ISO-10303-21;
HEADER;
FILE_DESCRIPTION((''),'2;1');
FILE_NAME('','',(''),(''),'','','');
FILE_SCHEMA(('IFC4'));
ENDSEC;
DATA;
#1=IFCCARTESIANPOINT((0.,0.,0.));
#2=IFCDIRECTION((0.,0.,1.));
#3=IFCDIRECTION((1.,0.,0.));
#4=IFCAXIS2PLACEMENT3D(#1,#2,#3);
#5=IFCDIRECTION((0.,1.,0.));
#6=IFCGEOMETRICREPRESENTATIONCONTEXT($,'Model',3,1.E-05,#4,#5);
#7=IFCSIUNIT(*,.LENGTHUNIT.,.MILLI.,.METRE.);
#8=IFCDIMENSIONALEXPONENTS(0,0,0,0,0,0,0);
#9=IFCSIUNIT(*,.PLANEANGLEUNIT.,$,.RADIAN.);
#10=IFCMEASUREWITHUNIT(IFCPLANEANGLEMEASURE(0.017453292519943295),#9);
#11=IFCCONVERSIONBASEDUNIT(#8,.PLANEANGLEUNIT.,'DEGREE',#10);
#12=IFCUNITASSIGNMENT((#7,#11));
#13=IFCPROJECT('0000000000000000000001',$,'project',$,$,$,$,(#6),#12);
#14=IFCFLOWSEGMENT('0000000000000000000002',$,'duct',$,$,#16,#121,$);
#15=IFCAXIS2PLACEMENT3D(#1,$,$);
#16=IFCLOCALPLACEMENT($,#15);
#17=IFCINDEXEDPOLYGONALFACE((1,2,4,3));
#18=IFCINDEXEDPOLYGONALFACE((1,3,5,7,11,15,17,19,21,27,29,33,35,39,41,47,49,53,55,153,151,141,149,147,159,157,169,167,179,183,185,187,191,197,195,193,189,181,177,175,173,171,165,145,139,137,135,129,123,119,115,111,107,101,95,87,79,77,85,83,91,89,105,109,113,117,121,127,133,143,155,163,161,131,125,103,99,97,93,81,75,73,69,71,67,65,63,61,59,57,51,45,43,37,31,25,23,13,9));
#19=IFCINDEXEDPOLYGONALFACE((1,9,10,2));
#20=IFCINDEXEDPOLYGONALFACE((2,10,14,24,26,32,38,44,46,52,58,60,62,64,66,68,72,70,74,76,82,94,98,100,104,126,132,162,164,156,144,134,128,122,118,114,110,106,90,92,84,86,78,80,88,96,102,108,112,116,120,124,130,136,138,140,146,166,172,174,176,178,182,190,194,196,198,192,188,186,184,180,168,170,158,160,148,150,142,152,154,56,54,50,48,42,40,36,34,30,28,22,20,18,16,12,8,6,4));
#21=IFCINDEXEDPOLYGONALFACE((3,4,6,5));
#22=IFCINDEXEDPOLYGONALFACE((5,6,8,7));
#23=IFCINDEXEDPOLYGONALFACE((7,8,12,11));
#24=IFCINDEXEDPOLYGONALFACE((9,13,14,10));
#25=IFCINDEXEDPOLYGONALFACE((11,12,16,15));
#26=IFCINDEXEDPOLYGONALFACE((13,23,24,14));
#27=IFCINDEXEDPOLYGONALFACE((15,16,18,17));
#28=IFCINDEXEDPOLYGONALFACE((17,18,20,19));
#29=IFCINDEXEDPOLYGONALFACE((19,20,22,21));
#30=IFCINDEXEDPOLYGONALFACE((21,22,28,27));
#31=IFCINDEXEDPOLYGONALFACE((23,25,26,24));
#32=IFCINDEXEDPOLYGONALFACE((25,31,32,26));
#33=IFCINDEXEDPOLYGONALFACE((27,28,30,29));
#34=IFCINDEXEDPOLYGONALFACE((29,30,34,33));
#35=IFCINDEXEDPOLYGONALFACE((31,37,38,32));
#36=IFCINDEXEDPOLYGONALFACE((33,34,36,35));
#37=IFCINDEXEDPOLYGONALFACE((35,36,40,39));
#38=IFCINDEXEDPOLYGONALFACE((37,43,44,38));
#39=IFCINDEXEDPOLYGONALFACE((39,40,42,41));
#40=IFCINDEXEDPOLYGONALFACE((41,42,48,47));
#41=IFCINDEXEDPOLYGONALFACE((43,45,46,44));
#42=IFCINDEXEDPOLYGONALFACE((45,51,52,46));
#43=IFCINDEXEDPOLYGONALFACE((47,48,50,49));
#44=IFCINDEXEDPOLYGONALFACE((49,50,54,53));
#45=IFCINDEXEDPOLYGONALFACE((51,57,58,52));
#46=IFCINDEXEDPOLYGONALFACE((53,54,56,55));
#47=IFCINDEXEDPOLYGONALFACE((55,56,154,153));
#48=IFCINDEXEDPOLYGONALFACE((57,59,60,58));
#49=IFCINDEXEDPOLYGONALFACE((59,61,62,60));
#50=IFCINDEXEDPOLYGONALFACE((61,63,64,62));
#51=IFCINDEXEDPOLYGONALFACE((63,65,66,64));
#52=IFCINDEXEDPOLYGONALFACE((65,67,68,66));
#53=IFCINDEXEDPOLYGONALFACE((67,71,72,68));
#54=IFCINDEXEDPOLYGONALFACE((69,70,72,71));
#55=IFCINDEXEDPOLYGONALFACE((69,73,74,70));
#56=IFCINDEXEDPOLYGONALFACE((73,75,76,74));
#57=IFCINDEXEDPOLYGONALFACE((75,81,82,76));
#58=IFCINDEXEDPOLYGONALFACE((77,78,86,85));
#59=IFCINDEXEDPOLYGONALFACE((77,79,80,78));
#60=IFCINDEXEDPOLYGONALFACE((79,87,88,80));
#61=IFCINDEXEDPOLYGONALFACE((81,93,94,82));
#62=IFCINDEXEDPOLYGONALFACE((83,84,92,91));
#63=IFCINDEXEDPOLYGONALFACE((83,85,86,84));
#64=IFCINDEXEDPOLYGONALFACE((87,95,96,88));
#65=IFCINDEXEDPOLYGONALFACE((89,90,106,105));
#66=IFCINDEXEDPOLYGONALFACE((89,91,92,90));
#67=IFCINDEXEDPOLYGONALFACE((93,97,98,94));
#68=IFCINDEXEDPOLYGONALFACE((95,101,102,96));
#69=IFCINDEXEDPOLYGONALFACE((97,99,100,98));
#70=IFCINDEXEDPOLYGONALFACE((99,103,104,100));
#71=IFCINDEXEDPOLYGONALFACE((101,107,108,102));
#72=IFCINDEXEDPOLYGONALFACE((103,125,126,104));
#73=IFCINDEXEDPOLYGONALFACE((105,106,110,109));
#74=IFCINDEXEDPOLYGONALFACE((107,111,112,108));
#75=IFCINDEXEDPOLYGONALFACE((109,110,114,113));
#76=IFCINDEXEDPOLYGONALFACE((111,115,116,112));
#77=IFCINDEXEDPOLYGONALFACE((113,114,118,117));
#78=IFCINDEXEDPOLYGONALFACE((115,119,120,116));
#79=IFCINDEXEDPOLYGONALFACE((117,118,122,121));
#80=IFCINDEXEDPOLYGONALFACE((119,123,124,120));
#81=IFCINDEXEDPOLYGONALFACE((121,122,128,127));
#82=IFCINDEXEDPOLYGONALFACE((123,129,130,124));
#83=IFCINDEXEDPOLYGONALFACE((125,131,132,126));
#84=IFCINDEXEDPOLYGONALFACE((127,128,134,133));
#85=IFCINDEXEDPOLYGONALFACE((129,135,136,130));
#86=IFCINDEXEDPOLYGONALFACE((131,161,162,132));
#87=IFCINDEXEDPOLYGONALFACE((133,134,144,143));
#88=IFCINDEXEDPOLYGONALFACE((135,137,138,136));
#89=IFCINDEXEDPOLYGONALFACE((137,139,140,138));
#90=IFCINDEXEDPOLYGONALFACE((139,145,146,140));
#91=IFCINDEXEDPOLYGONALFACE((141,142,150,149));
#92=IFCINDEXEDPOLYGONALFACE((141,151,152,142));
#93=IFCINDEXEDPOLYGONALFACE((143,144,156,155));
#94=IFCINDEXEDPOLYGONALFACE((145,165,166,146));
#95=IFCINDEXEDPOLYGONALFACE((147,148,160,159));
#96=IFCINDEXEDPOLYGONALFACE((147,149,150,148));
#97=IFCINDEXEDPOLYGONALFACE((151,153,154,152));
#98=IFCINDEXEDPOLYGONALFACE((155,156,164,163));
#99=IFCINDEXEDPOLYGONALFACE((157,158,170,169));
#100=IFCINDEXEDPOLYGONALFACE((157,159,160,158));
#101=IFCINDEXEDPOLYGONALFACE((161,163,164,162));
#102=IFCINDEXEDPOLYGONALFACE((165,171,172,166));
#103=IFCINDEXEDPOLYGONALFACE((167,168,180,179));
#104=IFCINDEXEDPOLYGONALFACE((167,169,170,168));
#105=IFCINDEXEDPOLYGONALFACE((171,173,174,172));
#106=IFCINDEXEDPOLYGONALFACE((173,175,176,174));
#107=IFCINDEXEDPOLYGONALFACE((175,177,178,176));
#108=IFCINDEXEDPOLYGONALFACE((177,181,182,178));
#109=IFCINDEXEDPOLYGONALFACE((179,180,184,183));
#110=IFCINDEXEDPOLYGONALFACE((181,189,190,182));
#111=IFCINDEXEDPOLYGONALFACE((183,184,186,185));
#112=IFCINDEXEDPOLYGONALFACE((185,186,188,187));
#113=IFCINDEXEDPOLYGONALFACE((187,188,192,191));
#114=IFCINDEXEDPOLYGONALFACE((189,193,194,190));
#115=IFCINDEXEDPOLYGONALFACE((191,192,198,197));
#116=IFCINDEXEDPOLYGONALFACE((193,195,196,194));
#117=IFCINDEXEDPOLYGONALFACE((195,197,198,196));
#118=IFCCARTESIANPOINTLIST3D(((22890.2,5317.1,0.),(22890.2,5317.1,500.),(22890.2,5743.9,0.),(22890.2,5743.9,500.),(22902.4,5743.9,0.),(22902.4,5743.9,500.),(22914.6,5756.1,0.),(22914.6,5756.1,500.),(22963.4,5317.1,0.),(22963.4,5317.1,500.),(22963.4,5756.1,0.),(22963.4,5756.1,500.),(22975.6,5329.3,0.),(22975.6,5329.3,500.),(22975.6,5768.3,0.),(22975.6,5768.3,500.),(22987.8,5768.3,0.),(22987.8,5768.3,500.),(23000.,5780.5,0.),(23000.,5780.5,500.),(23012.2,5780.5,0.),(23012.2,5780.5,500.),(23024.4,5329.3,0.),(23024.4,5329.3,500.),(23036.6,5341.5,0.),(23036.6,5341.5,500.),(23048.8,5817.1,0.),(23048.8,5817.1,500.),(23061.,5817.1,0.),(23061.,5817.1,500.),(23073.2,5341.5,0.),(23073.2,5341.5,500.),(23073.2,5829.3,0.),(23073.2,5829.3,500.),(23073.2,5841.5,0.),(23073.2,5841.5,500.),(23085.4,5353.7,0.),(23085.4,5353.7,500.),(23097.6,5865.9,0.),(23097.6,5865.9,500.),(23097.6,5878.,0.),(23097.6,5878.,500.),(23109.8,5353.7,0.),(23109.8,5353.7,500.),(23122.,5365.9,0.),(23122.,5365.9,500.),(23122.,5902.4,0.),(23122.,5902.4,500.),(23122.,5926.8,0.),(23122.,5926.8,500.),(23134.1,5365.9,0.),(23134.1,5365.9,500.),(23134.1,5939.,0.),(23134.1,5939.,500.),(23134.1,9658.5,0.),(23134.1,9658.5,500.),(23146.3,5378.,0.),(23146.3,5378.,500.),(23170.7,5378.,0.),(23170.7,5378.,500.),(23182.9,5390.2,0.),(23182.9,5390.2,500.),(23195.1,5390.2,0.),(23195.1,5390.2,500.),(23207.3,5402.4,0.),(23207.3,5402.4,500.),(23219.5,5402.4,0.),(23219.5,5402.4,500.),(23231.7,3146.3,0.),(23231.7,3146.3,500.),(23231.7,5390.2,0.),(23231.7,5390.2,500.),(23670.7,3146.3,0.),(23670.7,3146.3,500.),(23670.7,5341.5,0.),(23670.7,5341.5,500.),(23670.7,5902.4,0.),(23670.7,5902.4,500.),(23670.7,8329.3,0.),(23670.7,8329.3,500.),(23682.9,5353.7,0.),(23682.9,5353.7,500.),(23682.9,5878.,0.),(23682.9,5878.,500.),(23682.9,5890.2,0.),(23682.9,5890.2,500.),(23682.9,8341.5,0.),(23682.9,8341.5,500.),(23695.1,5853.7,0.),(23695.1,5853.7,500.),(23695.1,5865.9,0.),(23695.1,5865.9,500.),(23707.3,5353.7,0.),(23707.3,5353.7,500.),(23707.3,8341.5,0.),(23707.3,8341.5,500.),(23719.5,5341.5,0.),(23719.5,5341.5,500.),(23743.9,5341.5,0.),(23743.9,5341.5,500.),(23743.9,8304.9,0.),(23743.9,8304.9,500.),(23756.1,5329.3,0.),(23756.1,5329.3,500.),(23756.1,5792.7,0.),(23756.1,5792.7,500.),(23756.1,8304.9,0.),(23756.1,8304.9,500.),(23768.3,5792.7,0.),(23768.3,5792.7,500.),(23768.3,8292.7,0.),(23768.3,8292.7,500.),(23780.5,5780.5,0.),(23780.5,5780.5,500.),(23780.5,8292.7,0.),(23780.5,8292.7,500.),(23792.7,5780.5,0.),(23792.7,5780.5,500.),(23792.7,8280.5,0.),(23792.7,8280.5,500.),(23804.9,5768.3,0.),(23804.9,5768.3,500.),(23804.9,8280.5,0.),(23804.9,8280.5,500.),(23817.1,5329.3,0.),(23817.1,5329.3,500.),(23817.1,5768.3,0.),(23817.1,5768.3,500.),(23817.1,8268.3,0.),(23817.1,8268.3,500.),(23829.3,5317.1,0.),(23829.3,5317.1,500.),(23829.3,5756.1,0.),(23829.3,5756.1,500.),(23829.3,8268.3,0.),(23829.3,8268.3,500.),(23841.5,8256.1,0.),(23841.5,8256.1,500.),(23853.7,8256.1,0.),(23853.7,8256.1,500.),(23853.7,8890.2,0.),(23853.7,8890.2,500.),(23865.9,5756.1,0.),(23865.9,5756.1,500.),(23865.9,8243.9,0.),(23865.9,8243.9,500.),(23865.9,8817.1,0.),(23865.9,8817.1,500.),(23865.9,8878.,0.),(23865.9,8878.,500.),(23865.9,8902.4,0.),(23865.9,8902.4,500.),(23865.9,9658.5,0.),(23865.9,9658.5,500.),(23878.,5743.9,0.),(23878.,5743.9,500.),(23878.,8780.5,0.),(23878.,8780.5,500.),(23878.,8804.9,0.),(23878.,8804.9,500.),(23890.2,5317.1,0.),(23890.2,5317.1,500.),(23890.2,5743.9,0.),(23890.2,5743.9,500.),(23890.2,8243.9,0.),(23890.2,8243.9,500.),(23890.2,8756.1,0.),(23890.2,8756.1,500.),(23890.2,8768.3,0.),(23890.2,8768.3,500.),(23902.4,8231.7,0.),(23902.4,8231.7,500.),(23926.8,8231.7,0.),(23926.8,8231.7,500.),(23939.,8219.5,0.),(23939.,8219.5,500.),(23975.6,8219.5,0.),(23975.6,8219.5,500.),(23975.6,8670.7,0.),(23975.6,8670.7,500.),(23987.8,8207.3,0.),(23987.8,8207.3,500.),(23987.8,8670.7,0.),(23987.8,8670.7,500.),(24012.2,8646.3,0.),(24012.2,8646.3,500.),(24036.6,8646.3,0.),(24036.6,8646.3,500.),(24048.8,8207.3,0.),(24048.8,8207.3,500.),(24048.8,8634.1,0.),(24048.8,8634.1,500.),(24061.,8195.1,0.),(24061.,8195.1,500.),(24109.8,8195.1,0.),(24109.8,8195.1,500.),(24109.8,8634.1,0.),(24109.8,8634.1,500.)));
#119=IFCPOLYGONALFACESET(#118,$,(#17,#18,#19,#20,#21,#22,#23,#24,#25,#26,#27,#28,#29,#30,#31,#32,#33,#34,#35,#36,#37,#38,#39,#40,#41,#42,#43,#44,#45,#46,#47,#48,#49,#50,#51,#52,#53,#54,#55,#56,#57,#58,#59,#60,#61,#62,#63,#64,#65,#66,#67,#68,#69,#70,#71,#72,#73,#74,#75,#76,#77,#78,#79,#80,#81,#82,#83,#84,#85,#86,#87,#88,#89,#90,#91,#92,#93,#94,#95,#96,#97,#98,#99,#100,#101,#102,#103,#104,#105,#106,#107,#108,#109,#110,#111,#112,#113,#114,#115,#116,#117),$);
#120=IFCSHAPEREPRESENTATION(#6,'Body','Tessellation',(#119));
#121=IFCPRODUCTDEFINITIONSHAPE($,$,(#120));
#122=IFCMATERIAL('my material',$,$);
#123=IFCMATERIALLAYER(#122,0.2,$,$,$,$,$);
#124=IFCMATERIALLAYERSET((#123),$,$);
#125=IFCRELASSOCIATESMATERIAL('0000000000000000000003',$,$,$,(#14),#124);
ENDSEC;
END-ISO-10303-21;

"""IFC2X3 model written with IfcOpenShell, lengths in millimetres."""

from ifc_helpers import new_model, entity, si_unit, converted_unit, direction, origin_with_axes, place, context, project, polyline, outline, extrude, material, layer, layer_set, layer_usage, element, save


model = new_model("IFC2X3")

# Units and contexts
model_context = context("Model", 3, precision=1e-05, world=origin_with_axes(), true_north=direction((0.0, 1.0, 0.0)))
ifc_project = project(units=[si_unit("LENGTHUNIT", "METRE", prefix="MILLI"), converted_unit("PLANEANGLEUNIT", "DEGREE", entity("IfcPlaneAngleMeasure", 0.017453292519943295), si_unit("PLANEANGLEUNIT", "RADIAN"), dimensions=[0, 0, 0, 0, 0, 0, 0])], contexts=[model_context])

# Flow segment
ifc_material_1 = material(Name="my material")
ifc_layer_1 = layer(ifc_material_1, 0.2)
ifc_layer_set_1 = layer_set([ifc_layer_1])
ifc_layer_usage_1 = layer_usage(ifc_layer_set_1, "AXIS2", "POSITIVE", -0.1)
flow_segment_1_placement = place(None, origin_with_axes())
element("IfcFlowSegment", 1, at=flow_segment_1_placement, material=ifc_layer_usage_1, Name="duct", context=model_context, shape_type="SweptSolid", body=[
    extrude(outline(polyline([(22890.2, 5317.1), (22963.4, 5317.1), (22975.6, 5329.3), (23024.4, 5329.3), (23036.6, 5341.5), (23073.2, 5341.5), (23085.4, 5353.7), (23109.8, 5353.7), (23122.0, 5365.9), (23134.1, 5365.9), (23146.3, 5378.0), (23170.7, 5378.0), (23182.9, 5390.2), (23195.1, 5390.2), (23207.3, 5402.4), (23219.5, 5402.4), (23231.7, 5390.2), (23231.7, 3146.3), (23670.7, 3146.3), (23670.7, 5341.5), (23682.9, 5353.7), (23707.3, 5353.7), (23719.5, 5341.5), (23743.9, 5341.5), (23756.1, 5329.3), (23817.1, 5329.3), (23829.3, 5317.1), (23890.2, 5317.1), (23890.2, 5743.9), (23878.0, 5743.9), (23865.9, 5756.1), (23829.3, 5756.1), (23817.1, 5768.3), (23804.9, 5768.3), (23792.7, 5780.5), (23780.5, 5780.5), (23768.3, 5792.7), (23756.1, 5792.7), (23695.1, 5853.7), (23695.1, 5865.9), (23682.9, 5878.0), (23682.9, 5890.2), (23670.7, 5902.4), (23670.7, 8329.3), (23682.9, 8341.5), (23707.3, 8341.5), (23743.9, 8304.9), (23756.1, 8304.9), (23768.3, 8292.7), (23780.5, 8292.7), (23792.7, 8280.5), (23804.9, 8280.5), (23817.1, 8268.3), (23829.3, 8268.3), (23841.5, 8256.1), (23853.7, 8256.1), (23865.9, 8243.9), (23890.2, 8243.9), (23902.4, 8231.7), (23926.8, 8231.7), (23939.0, 8219.5), (23975.6, 8219.5), (23987.8, 8207.3), (24048.8, 8207.3), (24061.0, 8195.1), (24109.8, 8195.1), (24109.8, 8634.1), (24048.8, 8634.1), (24036.6, 8646.3), (24012.2, 8646.3), (23987.8, 8670.7), (23975.6, 8670.7), (23890.2, 8756.1), (23890.2, 8768.3), (23878.0, 8780.5), (23878.0, 8804.9), (23865.9, 8817.1), (23865.9, 8878.0), (23853.7, 8890.2), (23865.9, 8902.4), (23865.9, 9658.5), (23134.1, 9658.5), (23134.1, 5939.0), (23122.0, 5926.8), (23122.0, 5902.4), (23097.6, 5878.0), (23097.6, 5865.9), (23073.2, 5841.5), (23073.2, 5829.3), (23061.0, 5817.1), (23048.8, 5817.1), (23012.2, 5780.5), (23000.0, 5780.5), (22987.8, 5768.3), (22975.6, 5768.3), (22963.4, 5756.1), (22914.6, 5756.1), (22902.4, 5743.9), (22890.2, 5743.9), (22890.2, 5317.1)])), origin_with_axes(), (0.0, 0.0, 1.0), 500.0),
])

save(model, "model.ifc")
